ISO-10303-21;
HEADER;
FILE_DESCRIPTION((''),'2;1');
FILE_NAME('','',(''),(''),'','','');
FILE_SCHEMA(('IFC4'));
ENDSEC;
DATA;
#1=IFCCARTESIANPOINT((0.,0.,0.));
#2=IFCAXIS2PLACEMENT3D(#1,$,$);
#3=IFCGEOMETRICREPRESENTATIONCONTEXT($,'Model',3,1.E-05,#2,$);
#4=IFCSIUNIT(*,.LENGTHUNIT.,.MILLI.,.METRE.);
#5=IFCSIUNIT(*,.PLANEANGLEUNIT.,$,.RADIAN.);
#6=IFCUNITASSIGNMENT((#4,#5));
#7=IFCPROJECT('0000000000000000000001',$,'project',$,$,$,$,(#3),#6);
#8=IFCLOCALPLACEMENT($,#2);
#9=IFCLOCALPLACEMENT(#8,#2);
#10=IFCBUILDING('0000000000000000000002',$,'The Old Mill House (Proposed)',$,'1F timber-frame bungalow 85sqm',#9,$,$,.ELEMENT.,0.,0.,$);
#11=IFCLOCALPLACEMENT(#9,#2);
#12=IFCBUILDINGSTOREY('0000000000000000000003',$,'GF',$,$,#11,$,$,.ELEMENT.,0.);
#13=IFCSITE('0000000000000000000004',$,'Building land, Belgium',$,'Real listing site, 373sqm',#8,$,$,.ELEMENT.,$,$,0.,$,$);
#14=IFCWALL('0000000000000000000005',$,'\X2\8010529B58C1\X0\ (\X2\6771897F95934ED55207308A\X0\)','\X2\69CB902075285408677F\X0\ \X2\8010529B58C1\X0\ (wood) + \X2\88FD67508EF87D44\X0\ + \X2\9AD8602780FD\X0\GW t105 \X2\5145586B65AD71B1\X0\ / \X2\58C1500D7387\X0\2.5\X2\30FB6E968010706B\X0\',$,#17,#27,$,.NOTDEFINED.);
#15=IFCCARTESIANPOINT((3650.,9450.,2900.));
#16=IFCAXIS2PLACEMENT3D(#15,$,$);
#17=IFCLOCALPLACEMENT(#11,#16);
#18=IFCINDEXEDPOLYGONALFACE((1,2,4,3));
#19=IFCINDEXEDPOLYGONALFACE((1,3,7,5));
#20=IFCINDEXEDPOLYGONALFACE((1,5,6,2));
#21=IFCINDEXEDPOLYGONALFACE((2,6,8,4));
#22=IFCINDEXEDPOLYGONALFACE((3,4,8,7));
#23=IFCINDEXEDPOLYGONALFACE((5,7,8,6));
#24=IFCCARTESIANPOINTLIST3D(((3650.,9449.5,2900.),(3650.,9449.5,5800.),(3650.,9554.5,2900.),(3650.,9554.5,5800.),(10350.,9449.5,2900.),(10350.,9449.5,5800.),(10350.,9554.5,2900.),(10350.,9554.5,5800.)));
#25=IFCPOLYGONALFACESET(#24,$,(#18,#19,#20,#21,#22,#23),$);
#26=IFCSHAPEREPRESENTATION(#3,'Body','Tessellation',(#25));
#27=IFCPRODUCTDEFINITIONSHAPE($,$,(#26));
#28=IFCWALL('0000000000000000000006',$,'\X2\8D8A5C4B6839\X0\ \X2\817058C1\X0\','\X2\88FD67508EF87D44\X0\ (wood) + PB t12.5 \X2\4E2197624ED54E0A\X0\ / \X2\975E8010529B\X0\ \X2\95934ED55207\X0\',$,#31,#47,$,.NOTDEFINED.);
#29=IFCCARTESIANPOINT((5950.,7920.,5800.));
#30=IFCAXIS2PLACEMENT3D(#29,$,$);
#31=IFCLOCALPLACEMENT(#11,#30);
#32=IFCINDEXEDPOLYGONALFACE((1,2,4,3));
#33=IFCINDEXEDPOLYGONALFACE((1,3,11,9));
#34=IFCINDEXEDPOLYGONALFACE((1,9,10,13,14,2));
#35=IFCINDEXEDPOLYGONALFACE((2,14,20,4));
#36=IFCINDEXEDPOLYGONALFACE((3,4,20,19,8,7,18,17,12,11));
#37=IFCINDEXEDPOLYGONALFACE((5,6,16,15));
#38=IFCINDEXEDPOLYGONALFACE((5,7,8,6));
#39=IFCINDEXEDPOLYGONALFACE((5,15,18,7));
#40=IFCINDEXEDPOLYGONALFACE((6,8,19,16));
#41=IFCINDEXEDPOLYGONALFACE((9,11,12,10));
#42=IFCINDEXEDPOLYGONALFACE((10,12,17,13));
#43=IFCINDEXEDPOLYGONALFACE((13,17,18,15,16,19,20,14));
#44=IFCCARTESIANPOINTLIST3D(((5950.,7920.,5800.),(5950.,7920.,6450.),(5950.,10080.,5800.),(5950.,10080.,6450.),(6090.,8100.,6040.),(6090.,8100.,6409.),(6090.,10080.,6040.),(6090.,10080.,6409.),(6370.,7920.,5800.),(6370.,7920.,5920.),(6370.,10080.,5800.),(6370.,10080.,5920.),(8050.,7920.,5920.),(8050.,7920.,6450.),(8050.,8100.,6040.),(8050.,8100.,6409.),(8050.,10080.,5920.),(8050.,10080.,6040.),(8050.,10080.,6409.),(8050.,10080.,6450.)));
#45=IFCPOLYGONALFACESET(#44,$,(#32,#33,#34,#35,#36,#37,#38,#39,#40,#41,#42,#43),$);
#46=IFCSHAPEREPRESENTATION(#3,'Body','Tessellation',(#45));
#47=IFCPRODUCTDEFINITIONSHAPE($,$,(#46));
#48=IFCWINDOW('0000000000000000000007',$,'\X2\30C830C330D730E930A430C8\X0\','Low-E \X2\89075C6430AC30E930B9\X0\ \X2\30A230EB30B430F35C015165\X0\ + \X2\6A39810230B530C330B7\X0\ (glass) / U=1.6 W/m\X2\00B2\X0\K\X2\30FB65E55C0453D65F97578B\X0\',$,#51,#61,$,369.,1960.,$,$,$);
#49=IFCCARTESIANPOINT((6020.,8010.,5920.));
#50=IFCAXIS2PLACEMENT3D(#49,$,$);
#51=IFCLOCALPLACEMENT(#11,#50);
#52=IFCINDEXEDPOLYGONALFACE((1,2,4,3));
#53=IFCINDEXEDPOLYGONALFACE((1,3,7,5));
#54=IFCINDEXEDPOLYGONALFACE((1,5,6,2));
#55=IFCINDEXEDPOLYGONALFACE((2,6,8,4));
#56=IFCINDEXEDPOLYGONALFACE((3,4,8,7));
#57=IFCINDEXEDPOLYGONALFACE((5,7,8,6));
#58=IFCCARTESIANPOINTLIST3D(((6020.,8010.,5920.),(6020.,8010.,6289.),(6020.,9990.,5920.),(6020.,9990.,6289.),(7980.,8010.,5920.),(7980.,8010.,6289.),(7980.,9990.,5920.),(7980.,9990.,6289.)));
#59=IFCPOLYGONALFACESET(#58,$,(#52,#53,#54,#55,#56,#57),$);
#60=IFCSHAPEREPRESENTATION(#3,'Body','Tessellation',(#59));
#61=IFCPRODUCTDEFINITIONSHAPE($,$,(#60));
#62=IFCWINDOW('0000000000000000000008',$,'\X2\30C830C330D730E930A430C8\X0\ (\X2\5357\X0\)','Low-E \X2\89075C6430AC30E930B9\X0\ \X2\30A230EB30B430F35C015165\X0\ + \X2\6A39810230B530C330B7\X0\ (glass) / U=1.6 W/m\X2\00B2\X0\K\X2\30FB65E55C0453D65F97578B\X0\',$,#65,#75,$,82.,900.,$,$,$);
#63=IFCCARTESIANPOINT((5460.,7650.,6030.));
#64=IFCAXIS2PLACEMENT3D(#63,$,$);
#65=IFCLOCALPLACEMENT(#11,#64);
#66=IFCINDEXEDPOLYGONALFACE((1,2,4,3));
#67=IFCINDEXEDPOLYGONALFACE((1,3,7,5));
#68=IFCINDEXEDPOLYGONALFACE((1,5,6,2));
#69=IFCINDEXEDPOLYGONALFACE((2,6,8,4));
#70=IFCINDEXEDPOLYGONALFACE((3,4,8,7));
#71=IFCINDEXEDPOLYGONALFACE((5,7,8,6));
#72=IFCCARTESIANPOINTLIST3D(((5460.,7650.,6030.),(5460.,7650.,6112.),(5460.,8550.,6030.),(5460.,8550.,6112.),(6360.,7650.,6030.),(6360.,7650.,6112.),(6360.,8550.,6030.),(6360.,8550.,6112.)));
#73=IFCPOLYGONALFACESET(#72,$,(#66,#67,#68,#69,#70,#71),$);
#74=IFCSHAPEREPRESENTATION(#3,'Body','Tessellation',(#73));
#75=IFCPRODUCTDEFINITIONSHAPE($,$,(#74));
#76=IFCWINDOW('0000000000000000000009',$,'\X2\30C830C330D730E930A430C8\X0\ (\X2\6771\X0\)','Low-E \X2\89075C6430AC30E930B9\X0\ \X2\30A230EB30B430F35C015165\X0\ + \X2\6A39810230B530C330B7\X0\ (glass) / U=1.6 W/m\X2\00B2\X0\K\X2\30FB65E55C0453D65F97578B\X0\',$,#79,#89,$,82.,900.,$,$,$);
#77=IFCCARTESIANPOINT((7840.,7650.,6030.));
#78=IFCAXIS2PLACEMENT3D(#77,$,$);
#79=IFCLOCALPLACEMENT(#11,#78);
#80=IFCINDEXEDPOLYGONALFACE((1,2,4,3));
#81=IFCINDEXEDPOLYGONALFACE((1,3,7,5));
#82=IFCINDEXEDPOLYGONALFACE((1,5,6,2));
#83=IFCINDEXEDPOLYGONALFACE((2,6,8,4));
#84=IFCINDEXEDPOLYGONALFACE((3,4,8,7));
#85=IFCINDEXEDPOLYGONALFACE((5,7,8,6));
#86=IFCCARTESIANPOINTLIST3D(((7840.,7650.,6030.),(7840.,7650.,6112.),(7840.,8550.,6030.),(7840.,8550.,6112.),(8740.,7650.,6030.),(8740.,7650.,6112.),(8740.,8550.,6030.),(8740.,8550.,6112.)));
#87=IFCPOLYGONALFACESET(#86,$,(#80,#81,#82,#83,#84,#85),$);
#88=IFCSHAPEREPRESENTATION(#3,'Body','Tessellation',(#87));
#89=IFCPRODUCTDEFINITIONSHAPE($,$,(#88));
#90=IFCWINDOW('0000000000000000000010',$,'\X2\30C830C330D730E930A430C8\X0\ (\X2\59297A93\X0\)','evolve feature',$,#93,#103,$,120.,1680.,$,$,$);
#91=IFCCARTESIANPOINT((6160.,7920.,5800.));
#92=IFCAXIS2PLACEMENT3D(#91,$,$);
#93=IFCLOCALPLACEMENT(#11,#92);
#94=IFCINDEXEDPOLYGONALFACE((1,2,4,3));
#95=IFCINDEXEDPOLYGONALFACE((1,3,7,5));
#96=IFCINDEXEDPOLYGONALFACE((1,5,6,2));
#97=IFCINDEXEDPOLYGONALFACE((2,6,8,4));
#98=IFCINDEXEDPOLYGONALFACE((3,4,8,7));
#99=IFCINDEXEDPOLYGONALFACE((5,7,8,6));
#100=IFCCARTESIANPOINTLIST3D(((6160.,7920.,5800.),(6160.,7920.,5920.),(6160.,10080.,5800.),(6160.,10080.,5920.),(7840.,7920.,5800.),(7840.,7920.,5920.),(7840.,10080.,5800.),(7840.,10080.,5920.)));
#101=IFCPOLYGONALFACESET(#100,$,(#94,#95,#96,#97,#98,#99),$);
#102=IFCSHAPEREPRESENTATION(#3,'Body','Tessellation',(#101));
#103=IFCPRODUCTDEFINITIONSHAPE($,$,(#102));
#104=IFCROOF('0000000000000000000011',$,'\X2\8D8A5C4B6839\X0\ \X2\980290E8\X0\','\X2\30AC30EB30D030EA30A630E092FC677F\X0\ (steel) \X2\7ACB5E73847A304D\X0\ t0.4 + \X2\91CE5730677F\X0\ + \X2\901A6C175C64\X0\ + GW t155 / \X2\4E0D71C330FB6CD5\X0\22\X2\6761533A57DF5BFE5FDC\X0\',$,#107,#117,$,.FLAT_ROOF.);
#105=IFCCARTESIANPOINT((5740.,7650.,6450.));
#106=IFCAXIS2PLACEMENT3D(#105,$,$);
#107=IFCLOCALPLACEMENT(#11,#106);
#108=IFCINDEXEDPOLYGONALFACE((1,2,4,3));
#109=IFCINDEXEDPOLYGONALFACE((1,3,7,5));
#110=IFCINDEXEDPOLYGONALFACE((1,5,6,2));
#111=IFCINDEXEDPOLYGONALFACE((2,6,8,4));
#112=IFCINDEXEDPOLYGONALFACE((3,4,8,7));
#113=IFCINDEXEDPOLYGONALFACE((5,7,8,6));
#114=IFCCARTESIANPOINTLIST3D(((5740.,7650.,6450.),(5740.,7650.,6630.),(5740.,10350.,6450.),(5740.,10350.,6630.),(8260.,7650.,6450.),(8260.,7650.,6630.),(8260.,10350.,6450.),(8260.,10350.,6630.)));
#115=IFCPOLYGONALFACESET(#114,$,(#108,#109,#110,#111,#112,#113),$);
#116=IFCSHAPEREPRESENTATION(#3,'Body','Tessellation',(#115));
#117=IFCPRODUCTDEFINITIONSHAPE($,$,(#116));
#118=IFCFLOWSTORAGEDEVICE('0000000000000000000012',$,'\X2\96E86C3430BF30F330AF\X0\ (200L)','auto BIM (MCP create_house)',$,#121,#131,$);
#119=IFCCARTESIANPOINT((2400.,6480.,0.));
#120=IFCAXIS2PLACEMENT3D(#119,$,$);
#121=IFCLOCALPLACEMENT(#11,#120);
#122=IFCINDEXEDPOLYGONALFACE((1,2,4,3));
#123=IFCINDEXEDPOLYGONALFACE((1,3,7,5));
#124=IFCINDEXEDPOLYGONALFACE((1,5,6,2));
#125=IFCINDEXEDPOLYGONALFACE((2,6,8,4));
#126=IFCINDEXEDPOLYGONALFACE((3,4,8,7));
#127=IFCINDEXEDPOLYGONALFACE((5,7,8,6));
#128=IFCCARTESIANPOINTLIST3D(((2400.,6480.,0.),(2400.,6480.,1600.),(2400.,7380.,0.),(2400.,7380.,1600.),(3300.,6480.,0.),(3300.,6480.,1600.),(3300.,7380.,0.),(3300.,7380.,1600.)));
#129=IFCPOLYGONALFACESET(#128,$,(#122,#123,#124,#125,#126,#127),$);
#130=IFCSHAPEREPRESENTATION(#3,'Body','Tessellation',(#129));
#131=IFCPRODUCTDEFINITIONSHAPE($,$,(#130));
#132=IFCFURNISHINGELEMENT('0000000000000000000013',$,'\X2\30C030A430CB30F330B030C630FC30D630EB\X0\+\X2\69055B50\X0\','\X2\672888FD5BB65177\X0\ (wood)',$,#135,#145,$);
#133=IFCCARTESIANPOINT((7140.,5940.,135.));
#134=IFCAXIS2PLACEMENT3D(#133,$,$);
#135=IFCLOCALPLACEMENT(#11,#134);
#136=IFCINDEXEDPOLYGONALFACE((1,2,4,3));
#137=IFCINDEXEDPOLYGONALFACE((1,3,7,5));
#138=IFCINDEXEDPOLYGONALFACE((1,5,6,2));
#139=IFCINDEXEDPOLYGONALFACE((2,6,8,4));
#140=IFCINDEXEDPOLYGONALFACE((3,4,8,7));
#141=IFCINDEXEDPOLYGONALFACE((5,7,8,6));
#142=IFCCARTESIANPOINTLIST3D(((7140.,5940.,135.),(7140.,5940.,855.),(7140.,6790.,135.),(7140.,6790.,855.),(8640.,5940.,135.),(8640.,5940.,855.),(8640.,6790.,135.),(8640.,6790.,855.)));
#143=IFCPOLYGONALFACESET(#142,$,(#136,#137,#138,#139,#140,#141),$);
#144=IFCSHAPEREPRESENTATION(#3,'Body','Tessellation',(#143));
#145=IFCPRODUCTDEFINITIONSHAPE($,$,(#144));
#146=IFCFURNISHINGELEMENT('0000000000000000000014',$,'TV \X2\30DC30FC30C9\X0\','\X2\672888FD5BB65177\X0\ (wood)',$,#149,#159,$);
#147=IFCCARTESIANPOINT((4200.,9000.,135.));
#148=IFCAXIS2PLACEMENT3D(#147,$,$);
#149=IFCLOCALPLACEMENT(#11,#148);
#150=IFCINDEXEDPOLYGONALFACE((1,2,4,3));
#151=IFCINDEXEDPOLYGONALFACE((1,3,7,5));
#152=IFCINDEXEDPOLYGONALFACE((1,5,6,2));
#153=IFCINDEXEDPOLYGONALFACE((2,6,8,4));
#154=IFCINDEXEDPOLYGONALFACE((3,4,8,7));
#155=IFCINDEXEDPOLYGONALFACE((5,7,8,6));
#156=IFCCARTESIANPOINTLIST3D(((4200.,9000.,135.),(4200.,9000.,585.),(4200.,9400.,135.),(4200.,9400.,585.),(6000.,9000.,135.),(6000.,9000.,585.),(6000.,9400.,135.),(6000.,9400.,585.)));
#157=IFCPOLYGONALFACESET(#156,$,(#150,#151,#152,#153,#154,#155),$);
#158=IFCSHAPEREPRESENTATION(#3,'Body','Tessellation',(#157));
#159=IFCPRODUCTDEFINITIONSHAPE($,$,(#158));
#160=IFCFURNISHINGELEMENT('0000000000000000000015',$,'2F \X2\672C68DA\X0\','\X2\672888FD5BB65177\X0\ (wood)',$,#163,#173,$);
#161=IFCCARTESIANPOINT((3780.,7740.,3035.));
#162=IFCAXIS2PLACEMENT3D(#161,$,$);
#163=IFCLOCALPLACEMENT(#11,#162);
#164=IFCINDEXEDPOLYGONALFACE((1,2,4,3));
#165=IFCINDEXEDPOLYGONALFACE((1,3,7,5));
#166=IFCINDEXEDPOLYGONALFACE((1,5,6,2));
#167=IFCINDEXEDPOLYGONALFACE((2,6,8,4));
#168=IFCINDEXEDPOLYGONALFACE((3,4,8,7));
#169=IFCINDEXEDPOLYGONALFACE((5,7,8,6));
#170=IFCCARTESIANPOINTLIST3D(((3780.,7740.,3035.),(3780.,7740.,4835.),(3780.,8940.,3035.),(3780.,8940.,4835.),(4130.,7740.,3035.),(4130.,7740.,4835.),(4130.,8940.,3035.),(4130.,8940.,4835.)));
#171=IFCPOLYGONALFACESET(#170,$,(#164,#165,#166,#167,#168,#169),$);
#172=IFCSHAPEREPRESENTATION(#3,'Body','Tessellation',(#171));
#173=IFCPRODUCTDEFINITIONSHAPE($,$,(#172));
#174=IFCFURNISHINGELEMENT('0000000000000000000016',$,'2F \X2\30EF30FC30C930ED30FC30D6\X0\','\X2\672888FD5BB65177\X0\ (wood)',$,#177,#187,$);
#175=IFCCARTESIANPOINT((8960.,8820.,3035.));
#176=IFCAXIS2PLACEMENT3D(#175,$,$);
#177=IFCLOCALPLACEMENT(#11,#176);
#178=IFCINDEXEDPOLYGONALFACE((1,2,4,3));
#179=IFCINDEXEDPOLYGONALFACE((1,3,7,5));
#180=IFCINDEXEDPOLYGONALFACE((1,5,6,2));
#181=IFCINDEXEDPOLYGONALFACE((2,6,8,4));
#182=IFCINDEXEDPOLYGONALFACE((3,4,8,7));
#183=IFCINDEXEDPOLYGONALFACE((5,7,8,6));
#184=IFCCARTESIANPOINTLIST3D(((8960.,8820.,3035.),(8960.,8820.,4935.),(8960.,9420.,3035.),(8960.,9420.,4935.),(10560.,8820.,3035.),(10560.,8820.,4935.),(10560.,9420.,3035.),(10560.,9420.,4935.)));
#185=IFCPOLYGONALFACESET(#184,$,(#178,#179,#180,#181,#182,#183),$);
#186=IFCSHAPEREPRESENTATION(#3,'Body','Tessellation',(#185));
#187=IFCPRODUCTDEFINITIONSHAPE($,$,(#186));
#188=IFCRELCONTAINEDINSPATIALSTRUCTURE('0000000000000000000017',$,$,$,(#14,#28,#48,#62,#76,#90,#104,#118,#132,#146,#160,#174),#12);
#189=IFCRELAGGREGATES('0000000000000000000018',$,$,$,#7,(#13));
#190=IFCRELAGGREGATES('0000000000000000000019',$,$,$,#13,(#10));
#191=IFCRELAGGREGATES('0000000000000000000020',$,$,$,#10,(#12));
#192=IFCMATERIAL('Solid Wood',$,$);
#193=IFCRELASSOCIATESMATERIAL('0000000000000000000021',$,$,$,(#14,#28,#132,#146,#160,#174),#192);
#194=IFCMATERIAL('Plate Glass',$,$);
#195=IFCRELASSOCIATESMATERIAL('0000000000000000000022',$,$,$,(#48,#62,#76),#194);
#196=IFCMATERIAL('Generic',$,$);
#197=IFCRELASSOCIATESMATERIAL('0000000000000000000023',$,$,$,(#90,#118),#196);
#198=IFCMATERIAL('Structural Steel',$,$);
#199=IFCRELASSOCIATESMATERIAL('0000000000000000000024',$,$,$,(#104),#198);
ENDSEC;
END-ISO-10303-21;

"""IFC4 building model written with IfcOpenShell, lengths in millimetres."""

from ifc_helpers import new_model, si_unit, frame, frame_2d, origin, place, context, project, spatial, rectangle, extrude, material, element, fill, save


model = new_model("IFC4")

# Units and contexts
model_context = context("Model", 3, precision=1e-05, world=origin())
ifc_project = project(units=[si_unit("LENGTHUNIT", "METRE", prefix="MILLI"), si_unit("PLANEANGLEUNIT", "RADIAN")], contexts=[model_context])

# Site, building, storey
site_placement = place(None, origin())
site = spatial("IfcSite", under=ifc_project, at=site_placement, Name="Building land, Belgium", ObjectType="Real listing site, 373sqm", CompositionType="ELEMENT", RefElevation=0.0)
building_placement = place(site_placement, origin())
building = spatial("IfcBuilding", under=site, at=building_placement, Name="The Old Mill House (Proposed)", ObjectType="1F timber-frame bungalow 85sqm", CompositionType="ELEMENT", ElevationOfRefHeight=0.0, ElevationOfTerrain=0.0)
storey_placement = place(building_placement, origin())
storey = spatial("IfcBuildingStorey", under=building, at=storey_placement, Name="GF", CompositionType="ELEMENT", Elevation=0.0)

# Wall
ifc_material_1 = material(Name="Solid Wood")
wall_1_placement = place(storey_placement, frame((3650.0, 9450.0, 2900.0)))
element("IfcWall", 1, at=wall_1_placement, inside=storey, material=ifc_material_1, Name="耐力壁 (東西間仕切り)", Description="構造用合板 耐力壁 (wood) + 製材軸組 + 高性能GW t105 充填断熱 / 壁倍率2.5・準耐火", PredefinedType="NOTDEFINED", context=model_context, shape_type="SweptSolid", body=[
    extrude(rectangle(XDim=6700.0, YDim=105.0, at=frame_2d((3350.0, 52.0))), frame((3650.0, 9450.0, 2900.0)), (0.0, 0.0, 1.0), 2900.0),
])

# Wall, openings, windows
wall_2_placement = place(storey_placement, frame((5950.0, 7920.0, 5800.0)))
wall_2 = element("IfcWall", 2, at=wall_2_placement, inside=storey, material=ifc_material_1, Name="越屋根 腰壁", Description="製材軸組 (wood) + PB t12.5 両面仕上 / 非耐力 間仕切", PredefinedType="NOTDEFINED", context=model_context, shape_type="SweptSolid", body=[
    extrude(rectangle(XDim=2100.0, YDim=2160.0, at=frame_2d((1050.0, 1080.0))), frame((5950.0, 7920.0, 5800.0)), (0.0, 0.0, 1.0), 650.0),
])
opening_1_placement = place(storey_placement, frame((6020.0, 8010.0, 5920.0)))
opening_1 = element("IfcOpeningElement", 3, at=opening_1_placement, cuts=wall_2, PredefinedType="NOTDEFINED", context=model_context, shape_type="SweptSolid", body=[
    extrude(rectangle(XDim=1960.0, YDim=1980.0, at=frame_2d((980.0, 990.0))), frame((6020.0, 8010.0, 5920.0)), (0.0, 0.0, 1.0), 369.0),
])
opening_2_placement = place(storey_placement, frame((5460.0, 7650.0, 6030.0)))
opening_2 = element("IfcOpeningElement", 4, at=opening_2_placement, cuts=wall_2, PredefinedType="NOTDEFINED", context=model_context, shape_type="SweptSolid", body=[
    extrude(rectangle(XDim=900.0, YDim=900.0, at=frame_2d((450.0, 450.0))), frame((5460.0, 7650.0, 6030.0)), (0.0, 0.0, 1.0), 82.0),
])
opening_3_placement = place(storey_placement, frame((7840.0, 7650.0, 6030.0)))
opening_3 = element("IfcOpeningElement", 5, at=opening_3_placement, cuts=wall_2, PredefinedType="NOTDEFINED", context=model_context, shape_type="SweptSolid", body=[
    extrude(rectangle(XDim=900.0, YDim=900.0, at=frame_2d((450.0, 450.0))), frame((7840.0, 7650.0, 6030.0)), (0.0, 0.0, 1.0), 82.0),
])
opening_4_placement = place(storey_placement, frame((6160.0, 7920.0, 5800.0)))
opening_4 = element("IfcOpeningElement", 6, at=opening_4_placement, cuts=wall_2, PredefinedType="NOTDEFINED", context=model_context, shape_type="SweptSolid", body=[
    extrude(rectangle(XDim=1680.0, YDim=2160.0, at=frame_2d((840.0, 1080.0))), frame((6160.0, 7920.0, 5800.0)), (0.0, 0.0, 1.0), 120.0),
])
ifc_material_2 = material(Name="Plate Glass")
window_1_placement = place(storey_placement, frame((6020.0, 8010.0, 5920.0)))
window_1 = element("IfcWindow", 7, at=window_1_placement, inside=storey, material=ifc_material_2, Name="トップライト", Description="Low-E 複層ガラス アルゴン封入 + 樹脂サッシ (glass) / U=1.6 W/m²K・日射取得型", OverallHeight=369.0, OverallWidth=1960.0, context=model_context, shape_type="SweptSolid", body=[
    extrude(rectangle(XDim=1960.0, YDim=1980.0, at=frame_2d((980.0, 990.0))), frame((6020.0, 8010.0, 5920.0)), (0.0, 0.0, 1.0), 369.0),
])
fill(opening_1, window_1)
window_2_placement = place(storey_placement, frame((5460.0, 7650.0, 6030.0)))
window_2 = element("IfcWindow", 8, at=window_2_placement, inside=storey, material=ifc_material_2, Name="トップライト (南)", Description="Low-E 複層ガラス アルゴン封入 + 樹脂サッシ (glass) / U=1.6 W/m²K・日射取得型", OverallHeight=82.0, OverallWidth=900.0, context=model_context, shape_type="SweptSolid", body=[
    extrude(rectangle(XDim=900.0, YDim=900.0, at=frame_2d((450.0, 450.0))), frame((5460.0, 7650.0, 6030.0)), (0.0, 0.0, 1.0), 82.0),
])
fill(opening_2, window_2)
window_3_placement = place(storey_placement, frame((7840.0, 7650.0, 6030.0)))
window_3 = element("IfcWindow", 9, at=window_3_placement, inside=storey, material=ifc_material_2, Name="トップライト (東)", Description="Low-E 複層ガラス アルゴン封入 + 樹脂サッシ (glass) / U=1.6 W/m²K・日射取得型", OverallHeight=82.0, OverallWidth=900.0, context=model_context, shape_type="SweptSolid", body=[
    extrude(rectangle(XDim=900.0, YDim=900.0, at=frame_2d((450.0, 450.0))), frame((7840.0, 7650.0, 6030.0)), (0.0, 0.0, 1.0), 82.0),
])
fill(opening_3, window_3)
ifc_material_3 = material(Name="Generic")
window_4_placement = place(storey_placement, frame((6160.0, 7920.0, 5800.0)))
window_4 = element("IfcWindow", 10, at=window_4_placement, inside=storey, material=ifc_material_3, Name="トップライト (天窓)", Description="evolve feature", OverallHeight=120.0, OverallWidth=1680.0, context=model_context, shape_type="SweptSolid", body=[
    extrude(rectangle(XDim=1680.0, YDim=2160.0, at=frame_2d((840.0, 1080.0))), frame((6160.0, 7920.0, 5800.0)), (0.0, 0.0, 1.0), 120.0),
])
fill(opening_4, window_4)

# Roof
ifc_material_4 = material(Name="Structural Steel")
roof_placement = place(storey_placement, frame((5740.0, 7650.0, 6450.0)))
element("IfcRoof", 11, at=roof_placement, inside=storey, material=ifc_material_4, Name="越屋根 頂部", Description="ガルバリウム鋼板 (steel) 立平葺き t0.4 + 野地板 + 通気層 + GW t155 / 不燃・法22条区域対応", PredefinedType="FLAT_ROOF", context=model_context, shape_type="SweptSolid", body=[
    extrude(rectangle(XDim=2520.0, YDim=2700.0, at=frame_2d((1260.0, 1350.0))), frame((5740.0, 7650.0, 6450.0)), (0.0, 0.0, 1.0), 180.0),
])

# Flow storage device
flow_storage_device_placement = place(storey_placement, frame((2400.0, 6480.0, 0.0)))
element("IfcFlowStorageDevice", 12, at=flow_storage_device_placement, inside=storey, material=ifc_material_3, Name="雨水タンク (200L)", Description="auto BIM (MCP create_house)", context=model_context, shape_type="SweptSolid", body=[
    extrude(rectangle(XDim=900.0, YDim=900.0, at=frame_2d((450.0, 450.0))), frame((2400.0, 6480.0, 0.0)), (0.0, 0.0, 1.0), 1600.0),
])

# Furnishing elements
furnishing_1_placement = place(storey_placement, frame((7140.0, 5940.0, 135.0)))
element("IfcFurnishingElement", 13, at=furnishing_1_placement, inside=storey, material=ifc_material_1, Name="ダイニングテーブル+椅子", Description="木製家具 (wood)", context=model_context, shape_type="SweptSolid", body=[
    extrude(rectangle(XDim=1500.0, YDim=850.0, at=frame_2d((750.0, 425.0))), frame((7140.0, 5940.0, 135.0)), (0.0, 0.0, 1.0), 720.0),
])
furnishing_2_placement = place(storey_placement, frame((4200.0, 9000.0, 135.0)))
element("IfcFurnishingElement", 14, at=furnishing_2_placement, inside=storey, material=ifc_material_1, Name="TV ボード", Description="木製家具 (wood)", context=model_context, shape_type="SweptSolid", body=[
    extrude(rectangle(XDim=1800.0, YDim=400.0, at=frame_2d((900.0, 200.0))), frame((4200.0, 9000.0, 135.0)), (0.0, 0.0, 1.0), 450.0),
])
furnishing_3_placement = place(storey_placement, frame((3780.0, 7740.0, 3035.0)))
element("IfcFurnishingElement", 15, at=furnishing_3_placement, inside=storey, material=ifc_material_1, Name="2F 本棚", Description="木製家具 (wood)", context=model_context, shape_type="SweptSolid", body=[
    extrude(rectangle(XDim=350.0, YDim=1200.0, at=frame_2d((175.0, 600.0))), frame((3780.0, 7740.0, 3035.0)), (0.0, 0.0, 1.0), 1800.0),
])
furnishing_4_placement = place(storey_placement, frame((8960.0, 8820.0, 3035.0)))
element("IfcFurnishingElement", 16, at=furnishing_4_placement, inside=storey, material=ifc_material_1, Name="2F ワードローブ", Description="木製家具 (wood)", context=model_context, shape_type="SweptSolid", body=[
    extrude(rectangle(XDim=1600.0, YDim=600.0, at=frame_2d((800.0, 300.0))), frame((8960.0, 8820.0, 3035.0)), (0.0, 0.0, 1.0), 1900.0),
])

save(model, "model.ifc")
